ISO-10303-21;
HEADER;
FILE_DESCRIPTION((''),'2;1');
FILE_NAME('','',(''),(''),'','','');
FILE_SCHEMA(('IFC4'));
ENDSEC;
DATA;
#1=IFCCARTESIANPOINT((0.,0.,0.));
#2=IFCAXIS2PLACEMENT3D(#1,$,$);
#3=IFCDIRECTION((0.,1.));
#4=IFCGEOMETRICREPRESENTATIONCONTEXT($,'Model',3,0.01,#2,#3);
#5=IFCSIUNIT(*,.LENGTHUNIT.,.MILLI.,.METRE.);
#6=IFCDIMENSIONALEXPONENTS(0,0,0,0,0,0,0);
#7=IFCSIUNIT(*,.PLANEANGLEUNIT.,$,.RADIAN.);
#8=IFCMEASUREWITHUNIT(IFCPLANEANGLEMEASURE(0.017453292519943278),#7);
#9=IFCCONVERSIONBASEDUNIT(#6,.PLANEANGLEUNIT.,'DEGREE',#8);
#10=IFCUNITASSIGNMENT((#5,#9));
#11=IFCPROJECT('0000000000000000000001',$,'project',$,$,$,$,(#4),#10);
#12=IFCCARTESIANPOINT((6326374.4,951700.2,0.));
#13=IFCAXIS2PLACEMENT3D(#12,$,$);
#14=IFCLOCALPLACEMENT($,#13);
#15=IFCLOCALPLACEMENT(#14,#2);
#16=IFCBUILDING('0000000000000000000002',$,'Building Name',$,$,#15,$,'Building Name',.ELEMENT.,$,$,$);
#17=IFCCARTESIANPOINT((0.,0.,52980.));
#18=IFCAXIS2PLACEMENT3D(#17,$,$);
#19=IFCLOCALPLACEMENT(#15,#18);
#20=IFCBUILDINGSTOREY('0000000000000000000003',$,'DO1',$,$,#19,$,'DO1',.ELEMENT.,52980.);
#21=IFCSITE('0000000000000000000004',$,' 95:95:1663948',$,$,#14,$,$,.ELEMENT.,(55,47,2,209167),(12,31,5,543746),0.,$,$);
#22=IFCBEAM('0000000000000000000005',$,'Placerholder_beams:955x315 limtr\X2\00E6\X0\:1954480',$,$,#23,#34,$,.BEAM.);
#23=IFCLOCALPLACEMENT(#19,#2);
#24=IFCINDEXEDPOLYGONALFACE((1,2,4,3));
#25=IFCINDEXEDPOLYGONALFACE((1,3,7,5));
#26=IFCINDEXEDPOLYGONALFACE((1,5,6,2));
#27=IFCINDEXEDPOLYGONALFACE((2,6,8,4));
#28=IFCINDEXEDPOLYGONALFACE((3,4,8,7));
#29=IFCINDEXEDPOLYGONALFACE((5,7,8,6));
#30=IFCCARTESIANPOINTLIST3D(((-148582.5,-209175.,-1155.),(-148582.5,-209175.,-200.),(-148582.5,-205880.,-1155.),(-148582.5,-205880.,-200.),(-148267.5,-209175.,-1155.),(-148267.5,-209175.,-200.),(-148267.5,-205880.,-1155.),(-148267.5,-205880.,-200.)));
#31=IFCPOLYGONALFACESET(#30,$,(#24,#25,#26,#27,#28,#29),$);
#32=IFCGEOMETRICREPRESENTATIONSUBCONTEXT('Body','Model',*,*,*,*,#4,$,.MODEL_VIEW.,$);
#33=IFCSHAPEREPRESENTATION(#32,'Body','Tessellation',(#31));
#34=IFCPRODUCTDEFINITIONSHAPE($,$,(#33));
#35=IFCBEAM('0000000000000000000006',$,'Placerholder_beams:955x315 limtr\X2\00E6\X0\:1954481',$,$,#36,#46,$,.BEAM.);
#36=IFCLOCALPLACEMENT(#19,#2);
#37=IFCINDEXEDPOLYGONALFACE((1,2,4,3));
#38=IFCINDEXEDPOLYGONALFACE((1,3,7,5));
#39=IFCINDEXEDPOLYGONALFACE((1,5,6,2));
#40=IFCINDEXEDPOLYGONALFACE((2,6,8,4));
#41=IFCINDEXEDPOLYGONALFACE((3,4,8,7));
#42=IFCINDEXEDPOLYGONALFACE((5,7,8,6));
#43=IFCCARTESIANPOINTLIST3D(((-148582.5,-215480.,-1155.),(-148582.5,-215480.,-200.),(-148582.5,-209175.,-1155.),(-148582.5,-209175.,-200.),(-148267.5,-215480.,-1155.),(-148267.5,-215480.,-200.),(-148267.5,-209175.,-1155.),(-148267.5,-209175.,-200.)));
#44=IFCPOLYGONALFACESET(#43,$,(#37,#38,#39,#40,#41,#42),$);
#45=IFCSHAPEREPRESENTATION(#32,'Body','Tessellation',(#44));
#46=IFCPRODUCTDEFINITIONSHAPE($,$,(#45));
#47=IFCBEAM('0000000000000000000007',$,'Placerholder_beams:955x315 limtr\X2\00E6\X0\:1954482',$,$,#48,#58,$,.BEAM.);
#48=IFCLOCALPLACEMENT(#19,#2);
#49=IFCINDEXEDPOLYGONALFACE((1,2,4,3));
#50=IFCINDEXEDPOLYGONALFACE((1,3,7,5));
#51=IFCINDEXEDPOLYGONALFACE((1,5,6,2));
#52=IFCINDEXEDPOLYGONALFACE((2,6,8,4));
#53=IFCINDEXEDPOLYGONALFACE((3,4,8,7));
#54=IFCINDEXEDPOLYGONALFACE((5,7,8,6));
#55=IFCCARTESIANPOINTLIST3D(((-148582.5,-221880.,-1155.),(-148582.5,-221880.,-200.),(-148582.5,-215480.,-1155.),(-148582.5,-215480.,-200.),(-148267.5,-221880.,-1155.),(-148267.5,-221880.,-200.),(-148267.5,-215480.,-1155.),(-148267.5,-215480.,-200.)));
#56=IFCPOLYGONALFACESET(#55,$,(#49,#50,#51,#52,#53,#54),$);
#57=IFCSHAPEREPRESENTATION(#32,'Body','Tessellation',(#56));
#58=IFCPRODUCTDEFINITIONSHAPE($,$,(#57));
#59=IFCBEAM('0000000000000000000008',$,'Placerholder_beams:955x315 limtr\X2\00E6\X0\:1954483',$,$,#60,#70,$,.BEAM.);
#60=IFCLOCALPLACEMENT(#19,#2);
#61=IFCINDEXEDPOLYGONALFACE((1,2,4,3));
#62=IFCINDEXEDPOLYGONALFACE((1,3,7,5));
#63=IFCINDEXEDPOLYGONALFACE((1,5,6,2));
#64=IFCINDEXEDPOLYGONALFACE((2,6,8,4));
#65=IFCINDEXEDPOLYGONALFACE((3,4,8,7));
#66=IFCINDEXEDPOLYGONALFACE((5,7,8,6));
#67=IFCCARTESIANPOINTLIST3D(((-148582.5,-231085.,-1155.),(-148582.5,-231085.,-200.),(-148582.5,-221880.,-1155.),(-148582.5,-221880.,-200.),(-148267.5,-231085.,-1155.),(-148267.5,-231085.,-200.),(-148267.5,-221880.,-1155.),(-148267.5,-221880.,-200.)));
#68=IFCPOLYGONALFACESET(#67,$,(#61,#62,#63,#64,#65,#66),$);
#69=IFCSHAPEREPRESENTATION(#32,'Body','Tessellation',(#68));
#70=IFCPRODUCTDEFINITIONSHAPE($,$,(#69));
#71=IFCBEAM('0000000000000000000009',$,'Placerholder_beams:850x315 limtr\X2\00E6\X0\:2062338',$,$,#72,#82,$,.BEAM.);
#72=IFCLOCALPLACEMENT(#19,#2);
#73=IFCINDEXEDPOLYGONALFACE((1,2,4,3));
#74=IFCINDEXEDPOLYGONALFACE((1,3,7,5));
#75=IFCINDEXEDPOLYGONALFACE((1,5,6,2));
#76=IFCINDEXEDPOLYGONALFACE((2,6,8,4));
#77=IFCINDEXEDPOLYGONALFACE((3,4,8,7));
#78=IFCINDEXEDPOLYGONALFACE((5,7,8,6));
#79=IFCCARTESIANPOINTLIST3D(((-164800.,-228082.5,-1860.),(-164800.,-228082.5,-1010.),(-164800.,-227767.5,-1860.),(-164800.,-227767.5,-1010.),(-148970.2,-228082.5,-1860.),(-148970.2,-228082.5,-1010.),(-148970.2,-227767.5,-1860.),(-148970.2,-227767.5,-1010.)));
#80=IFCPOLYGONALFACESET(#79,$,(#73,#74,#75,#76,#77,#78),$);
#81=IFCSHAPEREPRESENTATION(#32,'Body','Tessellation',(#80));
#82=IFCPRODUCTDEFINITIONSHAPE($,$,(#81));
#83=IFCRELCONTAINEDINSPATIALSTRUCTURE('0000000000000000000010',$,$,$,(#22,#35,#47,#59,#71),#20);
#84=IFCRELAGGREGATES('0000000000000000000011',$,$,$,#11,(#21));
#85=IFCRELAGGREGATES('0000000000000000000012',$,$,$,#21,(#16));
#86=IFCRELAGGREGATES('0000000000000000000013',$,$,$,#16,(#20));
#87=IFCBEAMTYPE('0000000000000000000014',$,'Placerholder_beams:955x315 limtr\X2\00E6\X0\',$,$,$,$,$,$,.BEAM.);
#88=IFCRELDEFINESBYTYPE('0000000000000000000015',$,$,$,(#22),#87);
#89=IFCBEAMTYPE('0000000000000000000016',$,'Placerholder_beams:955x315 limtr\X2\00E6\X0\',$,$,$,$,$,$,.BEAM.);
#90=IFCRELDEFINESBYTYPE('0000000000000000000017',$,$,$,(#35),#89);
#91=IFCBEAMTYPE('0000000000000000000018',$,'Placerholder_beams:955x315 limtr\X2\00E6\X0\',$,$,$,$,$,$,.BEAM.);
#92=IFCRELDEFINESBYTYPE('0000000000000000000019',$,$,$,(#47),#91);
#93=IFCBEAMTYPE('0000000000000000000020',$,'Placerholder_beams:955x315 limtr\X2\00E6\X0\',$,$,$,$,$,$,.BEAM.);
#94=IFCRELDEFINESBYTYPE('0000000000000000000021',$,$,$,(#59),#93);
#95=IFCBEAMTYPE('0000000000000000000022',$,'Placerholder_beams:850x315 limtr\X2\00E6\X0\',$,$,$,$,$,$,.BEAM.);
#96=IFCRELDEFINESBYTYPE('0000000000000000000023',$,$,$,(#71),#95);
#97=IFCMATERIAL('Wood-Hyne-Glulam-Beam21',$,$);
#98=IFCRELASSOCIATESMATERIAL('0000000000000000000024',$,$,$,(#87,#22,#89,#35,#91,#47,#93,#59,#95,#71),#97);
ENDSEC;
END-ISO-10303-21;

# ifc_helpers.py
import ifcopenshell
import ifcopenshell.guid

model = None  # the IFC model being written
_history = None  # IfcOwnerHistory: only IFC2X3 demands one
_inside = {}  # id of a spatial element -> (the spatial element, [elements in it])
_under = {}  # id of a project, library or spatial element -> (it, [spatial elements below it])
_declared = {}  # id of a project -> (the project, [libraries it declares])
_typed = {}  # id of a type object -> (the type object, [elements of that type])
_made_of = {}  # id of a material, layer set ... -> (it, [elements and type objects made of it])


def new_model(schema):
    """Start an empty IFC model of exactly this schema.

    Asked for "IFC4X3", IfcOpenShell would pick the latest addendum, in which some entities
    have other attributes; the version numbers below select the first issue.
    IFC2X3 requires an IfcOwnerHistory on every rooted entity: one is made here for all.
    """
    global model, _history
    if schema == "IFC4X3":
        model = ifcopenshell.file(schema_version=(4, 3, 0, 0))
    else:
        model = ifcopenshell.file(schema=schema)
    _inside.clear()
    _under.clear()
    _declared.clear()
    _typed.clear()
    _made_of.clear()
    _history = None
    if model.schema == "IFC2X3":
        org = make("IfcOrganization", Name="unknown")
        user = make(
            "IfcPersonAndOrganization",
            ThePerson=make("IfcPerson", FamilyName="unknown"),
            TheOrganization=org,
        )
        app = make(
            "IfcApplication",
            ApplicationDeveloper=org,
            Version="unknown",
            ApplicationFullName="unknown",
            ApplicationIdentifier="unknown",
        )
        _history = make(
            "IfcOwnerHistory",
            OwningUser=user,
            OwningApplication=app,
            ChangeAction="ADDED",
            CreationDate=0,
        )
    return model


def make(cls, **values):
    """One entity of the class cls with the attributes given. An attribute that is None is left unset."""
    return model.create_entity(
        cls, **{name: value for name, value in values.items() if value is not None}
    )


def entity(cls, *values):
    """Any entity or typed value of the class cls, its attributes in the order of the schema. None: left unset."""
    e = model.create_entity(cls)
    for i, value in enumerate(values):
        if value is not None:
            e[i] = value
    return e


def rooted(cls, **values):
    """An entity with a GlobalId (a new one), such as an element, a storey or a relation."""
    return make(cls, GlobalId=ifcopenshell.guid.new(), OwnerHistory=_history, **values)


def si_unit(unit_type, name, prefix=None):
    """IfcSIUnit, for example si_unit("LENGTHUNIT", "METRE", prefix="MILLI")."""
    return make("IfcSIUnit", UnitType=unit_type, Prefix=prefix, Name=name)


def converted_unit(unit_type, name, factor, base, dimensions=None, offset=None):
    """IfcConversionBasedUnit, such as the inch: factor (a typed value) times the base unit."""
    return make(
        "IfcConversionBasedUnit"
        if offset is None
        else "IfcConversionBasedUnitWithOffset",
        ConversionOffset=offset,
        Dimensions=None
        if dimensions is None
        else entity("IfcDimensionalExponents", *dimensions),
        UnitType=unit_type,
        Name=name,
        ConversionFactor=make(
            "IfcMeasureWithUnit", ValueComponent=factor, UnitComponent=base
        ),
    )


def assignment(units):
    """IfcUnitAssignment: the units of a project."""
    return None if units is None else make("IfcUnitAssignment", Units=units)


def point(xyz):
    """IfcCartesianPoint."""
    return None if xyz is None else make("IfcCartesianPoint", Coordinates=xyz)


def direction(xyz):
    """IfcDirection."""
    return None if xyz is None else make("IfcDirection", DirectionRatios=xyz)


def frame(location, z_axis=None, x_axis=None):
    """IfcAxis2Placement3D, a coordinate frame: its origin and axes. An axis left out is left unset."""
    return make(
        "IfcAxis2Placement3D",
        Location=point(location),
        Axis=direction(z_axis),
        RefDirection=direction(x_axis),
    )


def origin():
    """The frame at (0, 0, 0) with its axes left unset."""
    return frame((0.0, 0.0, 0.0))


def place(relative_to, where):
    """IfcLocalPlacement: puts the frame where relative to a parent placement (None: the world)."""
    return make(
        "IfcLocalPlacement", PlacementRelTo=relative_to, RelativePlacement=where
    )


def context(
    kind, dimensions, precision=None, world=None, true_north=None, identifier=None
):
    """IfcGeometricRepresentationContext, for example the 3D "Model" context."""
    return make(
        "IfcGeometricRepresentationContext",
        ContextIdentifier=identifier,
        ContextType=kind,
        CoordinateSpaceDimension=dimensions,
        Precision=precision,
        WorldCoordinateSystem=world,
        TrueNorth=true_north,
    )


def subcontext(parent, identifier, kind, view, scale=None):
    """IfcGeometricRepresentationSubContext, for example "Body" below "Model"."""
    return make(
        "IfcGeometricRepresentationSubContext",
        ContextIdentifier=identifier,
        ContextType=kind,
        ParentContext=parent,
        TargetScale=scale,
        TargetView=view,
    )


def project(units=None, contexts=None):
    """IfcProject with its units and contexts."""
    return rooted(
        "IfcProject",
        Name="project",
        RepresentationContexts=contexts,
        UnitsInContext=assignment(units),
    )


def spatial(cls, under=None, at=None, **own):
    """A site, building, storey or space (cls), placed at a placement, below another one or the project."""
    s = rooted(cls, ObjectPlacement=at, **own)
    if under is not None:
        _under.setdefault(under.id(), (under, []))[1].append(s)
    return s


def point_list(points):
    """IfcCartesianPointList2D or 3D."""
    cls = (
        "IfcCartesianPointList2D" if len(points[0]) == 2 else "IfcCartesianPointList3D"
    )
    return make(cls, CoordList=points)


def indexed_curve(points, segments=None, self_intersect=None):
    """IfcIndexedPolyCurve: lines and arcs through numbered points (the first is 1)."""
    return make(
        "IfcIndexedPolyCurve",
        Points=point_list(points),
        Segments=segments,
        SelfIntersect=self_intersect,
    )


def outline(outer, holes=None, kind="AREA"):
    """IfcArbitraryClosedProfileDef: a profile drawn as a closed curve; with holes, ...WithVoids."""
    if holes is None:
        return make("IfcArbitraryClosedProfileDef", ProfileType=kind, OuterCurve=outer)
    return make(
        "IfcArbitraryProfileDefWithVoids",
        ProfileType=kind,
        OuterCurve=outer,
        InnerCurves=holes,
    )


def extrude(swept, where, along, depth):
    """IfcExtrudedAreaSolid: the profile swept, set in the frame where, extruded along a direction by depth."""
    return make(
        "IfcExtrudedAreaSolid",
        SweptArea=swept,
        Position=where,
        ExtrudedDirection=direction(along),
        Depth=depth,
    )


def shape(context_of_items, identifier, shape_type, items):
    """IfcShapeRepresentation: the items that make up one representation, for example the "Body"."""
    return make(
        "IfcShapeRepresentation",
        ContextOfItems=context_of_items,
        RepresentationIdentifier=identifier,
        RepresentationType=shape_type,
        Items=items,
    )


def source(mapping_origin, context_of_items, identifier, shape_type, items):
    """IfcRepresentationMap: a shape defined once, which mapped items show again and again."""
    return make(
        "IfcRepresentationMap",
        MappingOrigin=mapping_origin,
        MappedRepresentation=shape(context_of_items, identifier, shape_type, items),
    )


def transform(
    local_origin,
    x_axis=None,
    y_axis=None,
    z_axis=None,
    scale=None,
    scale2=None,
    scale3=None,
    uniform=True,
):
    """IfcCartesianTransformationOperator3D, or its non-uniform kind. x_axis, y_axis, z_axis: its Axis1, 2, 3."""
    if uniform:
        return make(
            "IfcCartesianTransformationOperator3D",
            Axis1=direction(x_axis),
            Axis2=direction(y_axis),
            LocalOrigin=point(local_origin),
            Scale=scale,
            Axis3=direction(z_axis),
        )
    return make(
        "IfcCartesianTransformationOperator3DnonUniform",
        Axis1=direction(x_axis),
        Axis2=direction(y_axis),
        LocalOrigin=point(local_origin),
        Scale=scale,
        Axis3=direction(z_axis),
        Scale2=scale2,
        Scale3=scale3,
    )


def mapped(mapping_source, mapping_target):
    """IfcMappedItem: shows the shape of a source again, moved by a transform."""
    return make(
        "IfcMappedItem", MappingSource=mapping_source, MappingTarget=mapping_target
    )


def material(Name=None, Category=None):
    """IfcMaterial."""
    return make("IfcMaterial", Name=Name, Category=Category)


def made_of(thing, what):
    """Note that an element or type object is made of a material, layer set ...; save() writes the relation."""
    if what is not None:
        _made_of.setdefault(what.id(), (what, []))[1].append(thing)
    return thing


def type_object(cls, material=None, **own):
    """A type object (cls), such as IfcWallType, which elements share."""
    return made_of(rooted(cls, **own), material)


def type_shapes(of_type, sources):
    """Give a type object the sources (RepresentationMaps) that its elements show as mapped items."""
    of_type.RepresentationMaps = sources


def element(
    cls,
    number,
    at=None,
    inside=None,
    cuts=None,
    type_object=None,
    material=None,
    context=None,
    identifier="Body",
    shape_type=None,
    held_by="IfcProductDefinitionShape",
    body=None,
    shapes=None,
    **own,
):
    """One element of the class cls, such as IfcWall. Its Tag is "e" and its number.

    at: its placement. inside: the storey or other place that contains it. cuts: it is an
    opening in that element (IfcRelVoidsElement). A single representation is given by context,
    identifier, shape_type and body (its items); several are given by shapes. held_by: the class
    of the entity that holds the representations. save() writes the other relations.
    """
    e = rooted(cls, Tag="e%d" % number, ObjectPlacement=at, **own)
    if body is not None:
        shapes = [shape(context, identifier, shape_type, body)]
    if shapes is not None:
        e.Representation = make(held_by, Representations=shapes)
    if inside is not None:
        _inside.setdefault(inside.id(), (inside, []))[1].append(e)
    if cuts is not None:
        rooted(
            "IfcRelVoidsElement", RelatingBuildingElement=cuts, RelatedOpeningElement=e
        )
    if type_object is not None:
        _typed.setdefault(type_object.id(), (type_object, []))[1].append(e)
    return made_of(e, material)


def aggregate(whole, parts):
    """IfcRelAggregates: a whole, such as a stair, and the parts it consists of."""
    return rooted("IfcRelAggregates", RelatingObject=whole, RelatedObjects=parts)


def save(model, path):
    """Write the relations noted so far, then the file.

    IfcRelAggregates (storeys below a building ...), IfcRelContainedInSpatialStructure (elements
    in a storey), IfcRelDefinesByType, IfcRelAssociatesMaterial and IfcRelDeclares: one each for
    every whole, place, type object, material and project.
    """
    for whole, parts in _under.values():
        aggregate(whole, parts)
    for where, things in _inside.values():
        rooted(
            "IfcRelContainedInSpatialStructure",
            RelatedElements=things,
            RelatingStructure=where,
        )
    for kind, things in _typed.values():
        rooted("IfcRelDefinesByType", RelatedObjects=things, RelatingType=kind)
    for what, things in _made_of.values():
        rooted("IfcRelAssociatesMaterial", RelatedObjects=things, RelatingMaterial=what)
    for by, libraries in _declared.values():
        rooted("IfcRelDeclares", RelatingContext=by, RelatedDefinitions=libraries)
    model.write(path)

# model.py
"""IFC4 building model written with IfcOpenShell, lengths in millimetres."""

from ifc_helpers import new_model, entity, si_unit, converted_unit, direction, frame, origin, place, context, subcontext, project, spatial, indexed_curve, outline, extrude, source, transform, mapped, material, type_object, type_shapes, element, save


model = new_model("IFC4")

# Units and contexts
model_context = context("Model", 3, precision=0.01, world=origin(), true_north=direction((0.0, 1.0)))
body_context = subcontext(model_context, "Body", "Model", "MODEL_VIEW")
ifc_project = project(units=[si_unit("LENGTHUNIT", "METRE", prefix="MILLI"), converted_unit("PLANEANGLEUNIT", "DEGREE", entity("IfcPlaneAngleMeasure", 0.017453292519943278), si_unit("PLANEANGLEUNIT", "RADIAN"), dimensions=[0, 0, 0, 0, 0, 0, 0])], contexts=[model_context])

# Site, building, storey
site_placement = place(None, frame((6326374.4, 951700.2, 0.0)))
site = spatial("IfcSite", under=ifc_project, at=site_placement, Name=" 95:95:1663948", CompositionType="ELEMENT", RefLatitude=(55, 47, 2, 209167), RefLongitude=(12, 31, 5, 543746), RefElevation=0.0)
building_placement = place(site_placement, origin())
building = spatial("IfcBuilding", under=site, at=building_placement, Name="Building Name", LongName="Building Name", CompositionType="ELEMENT")
storey_placement = place(building_placement, frame((0.0, 0.0, 52980.0)))
storey = spatial("IfcBuildingStorey", under=building, at=storey_placement, Name="DO1", LongName="DO1", CompositionType="ELEMENT", Elevation=52980.0)

# Beams
ifc_material_1 = material(Name="Wood-Hyne-Glulam-Beam21")
beam_type_1 = type_object("IfcBeamType", Name="Placerholder_beams:955x315 limtræ", PredefinedType="BEAM", material=ifc_material_1)
shared_shape_1 = source(origin(), body_context, "Body", "SweptSolid", [
    extrude(outline(indexed_curve([(-1647.5, -157.5), (1647.5, -157.5), (1647.5, 157.5), (-1647.5, 157.5), (-1647.5, -157.5)], self_intersect=False)), frame((47.5, 0.0, -477.5)), (0.0, 0.0, 1.0), 955.0),
])
type_shapes(beam_type_1, [shared_shape_1])
beam_1_placement = place(storey_placement, frame((-148425.0, -207480.0, -677.5), z_axis=(0.0, 0.0, 1.0), x_axis=(0.0, -1.0, 0.0)))
element("IfcBeam", 1, at=beam_1_placement, inside=storey, type_object=beam_type_1, material=ifc_material_1, Name="Placerholder_beams:955x315 limtræ:1954480", PredefinedType="BEAM", context=body_context, shape_type="MappedRepresentation", body=[
    mapped(shared_shape_1, transform((0.0, 0.0, 0.0), scale=1.0)),
])
beam_type_2 = type_object("IfcBeamType", Name="Placerholder_beams:955x315 limtræ", PredefinedType="BEAM", material=ifc_material_1)
shared_shape_2 = source(origin(), body_context, "Body", "SweptSolid", [
    extrude(outline(indexed_curve([(-3152.5, -157.5), (3152.5, -157.5), (3152.5, 157.5), (-3152.5, 157.5), (-3152.5, -157.5)], self_intersect=False)), frame((47.5, 0.0, -477.5)), (0.0, 0.0, 1.0), 955.0),
])
type_shapes(beam_type_2, [shared_shape_2])
beam_2_placement = place(storey_placement, frame((-148425.0, -212280.0, -677.5), z_axis=(0.0, 0.0, 1.0), x_axis=(0.0, -1.0, 0.0)))
element("IfcBeam", 2, at=beam_2_placement, inside=storey, type_object=beam_type_2, material=ifc_material_1, Name="Placerholder_beams:955x315 limtræ:1954481", PredefinedType="BEAM", context=body_context, shape_type="MappedRepresentation", body=[
    mapped(shared_shape_2, transform((0.0, 0.0, 0.0), scale=1.0)),
])
beam_type_3 = type_object("IfcBeamType", Name="Placerholder_beams:955x315 limtræ", PredefinedType="BEAM", material=ifc_material_1)
shared_shape_3 = source(origin(), body_context, "Body", "SweptSolid", [
    extrude(outline(indexed_curve([(-3200.0, -157.5), (3200.0, -157.5), (3200.0, 157.5), (-3200.0, 157.5), (-3200.0, -157.5)], self_intersect=False)), frame((0.0, 0.0, -477.5)), (0.0, 0.0, 1.0), 955.0),
])
type_shapes(beam_type_3, [shared_shape_3])
beam_3_placement = place(storey_placement, frame((-148425.0, -218680.0, -677.5), z_axis=(0.0, 0.0, 1.0), x_axis=(0.0, -1.0, 0.0)))
element("IfcBeam", 3, at=beam_3_placement, inside=storey, type_object=beam_type_3, material=ifc_material_1, Name="Placerholder_beams:955x315 limtræ:1954482", PredefinedType="BEAM", context=body_context, shape_type="MappedRepresentation", body=[
    mapped(shared_shape_3, transform((0.0, 0.0, 0.0), scale=1.0)),
])
beam_type_4 = type_object("IfcBeamType", Name="Placerholder_beams:955x315 limtræ", PredefinedType="BEAM", material=ifc_material_1)
shared_shape_4 = source(origin(), body_context, "Body", "SweptSolid", [
    extrude(outline(indexed_curve([(-4602.5, -157.5), (4602.5, -157.5), (4602.5, 157.5), (-4602.5, 157.5), (-4602.5, -157.5)], self_intersect=False)), frame((0.0, 0.0, -477.5)), (0.0, 0.0, 1.0), 955.0),
])
type_shapes(beam_type_4, [shared_shape_4])
beam_4_placement = place(storey_placement, frame((-148425.0, -226482.5, -677.5), z_axis=(0.0, 0.0, 1.0), x_axis=(0.0, -1.0, 0.0)))
element("IfcBeam", 4, at=beam_4_placement, inside=storey, type_object=beam_type_4, material=ifc_material_1, Name="Placerholder_beams:955x315 limtræ:1954483", PredefinedType="BEAM", context=body_context, shape_type="MappedRepresentation", body=[
    mapped(shared_shape_4, transform((0.0, 0.0, 0.0), scale=1.0)),
])
beam_type_5 = type_object("IfcBeamType", Name="Placerholder_beams:850x315 limtræ", PredefinedType="BEAM", material=ifc_material_1)
shared_shape_5 = source(origin(), body_context, "Body", "SweptSolid", [
    extrude(outline(indexed_curve([(-7914.9, -157.5), (7914.9, -157.5), (7914.9, 157.5), (-7914.9, 157.5), (-7914.9, -157.5)], self_intersect=False)), frame((-85.2, 0.0, -425.0)), (0.0, 0.0, 1.0), 850.0),
])
type_shapes(beam_type_5, [shared_shape_5])
beam_5_placement = place(storey_placement, frame((-156799.9, -227925.0, -1435.0)))
element("IfcBeam", 5, at=beam_5_placement, inside=storey, type_object=beam_type_5, material=ifc_material_1, Name="Placerholder_beams:850x315 limtræ:2062338", PredefinedType="BEAM", context=body_context, shape_type="MappedRepresentation", body=[
    mapped(shared_shape_5, transform((0.0, 0.0, 0.0), scale=1.0)),
])

save(model, "model.ifc")
